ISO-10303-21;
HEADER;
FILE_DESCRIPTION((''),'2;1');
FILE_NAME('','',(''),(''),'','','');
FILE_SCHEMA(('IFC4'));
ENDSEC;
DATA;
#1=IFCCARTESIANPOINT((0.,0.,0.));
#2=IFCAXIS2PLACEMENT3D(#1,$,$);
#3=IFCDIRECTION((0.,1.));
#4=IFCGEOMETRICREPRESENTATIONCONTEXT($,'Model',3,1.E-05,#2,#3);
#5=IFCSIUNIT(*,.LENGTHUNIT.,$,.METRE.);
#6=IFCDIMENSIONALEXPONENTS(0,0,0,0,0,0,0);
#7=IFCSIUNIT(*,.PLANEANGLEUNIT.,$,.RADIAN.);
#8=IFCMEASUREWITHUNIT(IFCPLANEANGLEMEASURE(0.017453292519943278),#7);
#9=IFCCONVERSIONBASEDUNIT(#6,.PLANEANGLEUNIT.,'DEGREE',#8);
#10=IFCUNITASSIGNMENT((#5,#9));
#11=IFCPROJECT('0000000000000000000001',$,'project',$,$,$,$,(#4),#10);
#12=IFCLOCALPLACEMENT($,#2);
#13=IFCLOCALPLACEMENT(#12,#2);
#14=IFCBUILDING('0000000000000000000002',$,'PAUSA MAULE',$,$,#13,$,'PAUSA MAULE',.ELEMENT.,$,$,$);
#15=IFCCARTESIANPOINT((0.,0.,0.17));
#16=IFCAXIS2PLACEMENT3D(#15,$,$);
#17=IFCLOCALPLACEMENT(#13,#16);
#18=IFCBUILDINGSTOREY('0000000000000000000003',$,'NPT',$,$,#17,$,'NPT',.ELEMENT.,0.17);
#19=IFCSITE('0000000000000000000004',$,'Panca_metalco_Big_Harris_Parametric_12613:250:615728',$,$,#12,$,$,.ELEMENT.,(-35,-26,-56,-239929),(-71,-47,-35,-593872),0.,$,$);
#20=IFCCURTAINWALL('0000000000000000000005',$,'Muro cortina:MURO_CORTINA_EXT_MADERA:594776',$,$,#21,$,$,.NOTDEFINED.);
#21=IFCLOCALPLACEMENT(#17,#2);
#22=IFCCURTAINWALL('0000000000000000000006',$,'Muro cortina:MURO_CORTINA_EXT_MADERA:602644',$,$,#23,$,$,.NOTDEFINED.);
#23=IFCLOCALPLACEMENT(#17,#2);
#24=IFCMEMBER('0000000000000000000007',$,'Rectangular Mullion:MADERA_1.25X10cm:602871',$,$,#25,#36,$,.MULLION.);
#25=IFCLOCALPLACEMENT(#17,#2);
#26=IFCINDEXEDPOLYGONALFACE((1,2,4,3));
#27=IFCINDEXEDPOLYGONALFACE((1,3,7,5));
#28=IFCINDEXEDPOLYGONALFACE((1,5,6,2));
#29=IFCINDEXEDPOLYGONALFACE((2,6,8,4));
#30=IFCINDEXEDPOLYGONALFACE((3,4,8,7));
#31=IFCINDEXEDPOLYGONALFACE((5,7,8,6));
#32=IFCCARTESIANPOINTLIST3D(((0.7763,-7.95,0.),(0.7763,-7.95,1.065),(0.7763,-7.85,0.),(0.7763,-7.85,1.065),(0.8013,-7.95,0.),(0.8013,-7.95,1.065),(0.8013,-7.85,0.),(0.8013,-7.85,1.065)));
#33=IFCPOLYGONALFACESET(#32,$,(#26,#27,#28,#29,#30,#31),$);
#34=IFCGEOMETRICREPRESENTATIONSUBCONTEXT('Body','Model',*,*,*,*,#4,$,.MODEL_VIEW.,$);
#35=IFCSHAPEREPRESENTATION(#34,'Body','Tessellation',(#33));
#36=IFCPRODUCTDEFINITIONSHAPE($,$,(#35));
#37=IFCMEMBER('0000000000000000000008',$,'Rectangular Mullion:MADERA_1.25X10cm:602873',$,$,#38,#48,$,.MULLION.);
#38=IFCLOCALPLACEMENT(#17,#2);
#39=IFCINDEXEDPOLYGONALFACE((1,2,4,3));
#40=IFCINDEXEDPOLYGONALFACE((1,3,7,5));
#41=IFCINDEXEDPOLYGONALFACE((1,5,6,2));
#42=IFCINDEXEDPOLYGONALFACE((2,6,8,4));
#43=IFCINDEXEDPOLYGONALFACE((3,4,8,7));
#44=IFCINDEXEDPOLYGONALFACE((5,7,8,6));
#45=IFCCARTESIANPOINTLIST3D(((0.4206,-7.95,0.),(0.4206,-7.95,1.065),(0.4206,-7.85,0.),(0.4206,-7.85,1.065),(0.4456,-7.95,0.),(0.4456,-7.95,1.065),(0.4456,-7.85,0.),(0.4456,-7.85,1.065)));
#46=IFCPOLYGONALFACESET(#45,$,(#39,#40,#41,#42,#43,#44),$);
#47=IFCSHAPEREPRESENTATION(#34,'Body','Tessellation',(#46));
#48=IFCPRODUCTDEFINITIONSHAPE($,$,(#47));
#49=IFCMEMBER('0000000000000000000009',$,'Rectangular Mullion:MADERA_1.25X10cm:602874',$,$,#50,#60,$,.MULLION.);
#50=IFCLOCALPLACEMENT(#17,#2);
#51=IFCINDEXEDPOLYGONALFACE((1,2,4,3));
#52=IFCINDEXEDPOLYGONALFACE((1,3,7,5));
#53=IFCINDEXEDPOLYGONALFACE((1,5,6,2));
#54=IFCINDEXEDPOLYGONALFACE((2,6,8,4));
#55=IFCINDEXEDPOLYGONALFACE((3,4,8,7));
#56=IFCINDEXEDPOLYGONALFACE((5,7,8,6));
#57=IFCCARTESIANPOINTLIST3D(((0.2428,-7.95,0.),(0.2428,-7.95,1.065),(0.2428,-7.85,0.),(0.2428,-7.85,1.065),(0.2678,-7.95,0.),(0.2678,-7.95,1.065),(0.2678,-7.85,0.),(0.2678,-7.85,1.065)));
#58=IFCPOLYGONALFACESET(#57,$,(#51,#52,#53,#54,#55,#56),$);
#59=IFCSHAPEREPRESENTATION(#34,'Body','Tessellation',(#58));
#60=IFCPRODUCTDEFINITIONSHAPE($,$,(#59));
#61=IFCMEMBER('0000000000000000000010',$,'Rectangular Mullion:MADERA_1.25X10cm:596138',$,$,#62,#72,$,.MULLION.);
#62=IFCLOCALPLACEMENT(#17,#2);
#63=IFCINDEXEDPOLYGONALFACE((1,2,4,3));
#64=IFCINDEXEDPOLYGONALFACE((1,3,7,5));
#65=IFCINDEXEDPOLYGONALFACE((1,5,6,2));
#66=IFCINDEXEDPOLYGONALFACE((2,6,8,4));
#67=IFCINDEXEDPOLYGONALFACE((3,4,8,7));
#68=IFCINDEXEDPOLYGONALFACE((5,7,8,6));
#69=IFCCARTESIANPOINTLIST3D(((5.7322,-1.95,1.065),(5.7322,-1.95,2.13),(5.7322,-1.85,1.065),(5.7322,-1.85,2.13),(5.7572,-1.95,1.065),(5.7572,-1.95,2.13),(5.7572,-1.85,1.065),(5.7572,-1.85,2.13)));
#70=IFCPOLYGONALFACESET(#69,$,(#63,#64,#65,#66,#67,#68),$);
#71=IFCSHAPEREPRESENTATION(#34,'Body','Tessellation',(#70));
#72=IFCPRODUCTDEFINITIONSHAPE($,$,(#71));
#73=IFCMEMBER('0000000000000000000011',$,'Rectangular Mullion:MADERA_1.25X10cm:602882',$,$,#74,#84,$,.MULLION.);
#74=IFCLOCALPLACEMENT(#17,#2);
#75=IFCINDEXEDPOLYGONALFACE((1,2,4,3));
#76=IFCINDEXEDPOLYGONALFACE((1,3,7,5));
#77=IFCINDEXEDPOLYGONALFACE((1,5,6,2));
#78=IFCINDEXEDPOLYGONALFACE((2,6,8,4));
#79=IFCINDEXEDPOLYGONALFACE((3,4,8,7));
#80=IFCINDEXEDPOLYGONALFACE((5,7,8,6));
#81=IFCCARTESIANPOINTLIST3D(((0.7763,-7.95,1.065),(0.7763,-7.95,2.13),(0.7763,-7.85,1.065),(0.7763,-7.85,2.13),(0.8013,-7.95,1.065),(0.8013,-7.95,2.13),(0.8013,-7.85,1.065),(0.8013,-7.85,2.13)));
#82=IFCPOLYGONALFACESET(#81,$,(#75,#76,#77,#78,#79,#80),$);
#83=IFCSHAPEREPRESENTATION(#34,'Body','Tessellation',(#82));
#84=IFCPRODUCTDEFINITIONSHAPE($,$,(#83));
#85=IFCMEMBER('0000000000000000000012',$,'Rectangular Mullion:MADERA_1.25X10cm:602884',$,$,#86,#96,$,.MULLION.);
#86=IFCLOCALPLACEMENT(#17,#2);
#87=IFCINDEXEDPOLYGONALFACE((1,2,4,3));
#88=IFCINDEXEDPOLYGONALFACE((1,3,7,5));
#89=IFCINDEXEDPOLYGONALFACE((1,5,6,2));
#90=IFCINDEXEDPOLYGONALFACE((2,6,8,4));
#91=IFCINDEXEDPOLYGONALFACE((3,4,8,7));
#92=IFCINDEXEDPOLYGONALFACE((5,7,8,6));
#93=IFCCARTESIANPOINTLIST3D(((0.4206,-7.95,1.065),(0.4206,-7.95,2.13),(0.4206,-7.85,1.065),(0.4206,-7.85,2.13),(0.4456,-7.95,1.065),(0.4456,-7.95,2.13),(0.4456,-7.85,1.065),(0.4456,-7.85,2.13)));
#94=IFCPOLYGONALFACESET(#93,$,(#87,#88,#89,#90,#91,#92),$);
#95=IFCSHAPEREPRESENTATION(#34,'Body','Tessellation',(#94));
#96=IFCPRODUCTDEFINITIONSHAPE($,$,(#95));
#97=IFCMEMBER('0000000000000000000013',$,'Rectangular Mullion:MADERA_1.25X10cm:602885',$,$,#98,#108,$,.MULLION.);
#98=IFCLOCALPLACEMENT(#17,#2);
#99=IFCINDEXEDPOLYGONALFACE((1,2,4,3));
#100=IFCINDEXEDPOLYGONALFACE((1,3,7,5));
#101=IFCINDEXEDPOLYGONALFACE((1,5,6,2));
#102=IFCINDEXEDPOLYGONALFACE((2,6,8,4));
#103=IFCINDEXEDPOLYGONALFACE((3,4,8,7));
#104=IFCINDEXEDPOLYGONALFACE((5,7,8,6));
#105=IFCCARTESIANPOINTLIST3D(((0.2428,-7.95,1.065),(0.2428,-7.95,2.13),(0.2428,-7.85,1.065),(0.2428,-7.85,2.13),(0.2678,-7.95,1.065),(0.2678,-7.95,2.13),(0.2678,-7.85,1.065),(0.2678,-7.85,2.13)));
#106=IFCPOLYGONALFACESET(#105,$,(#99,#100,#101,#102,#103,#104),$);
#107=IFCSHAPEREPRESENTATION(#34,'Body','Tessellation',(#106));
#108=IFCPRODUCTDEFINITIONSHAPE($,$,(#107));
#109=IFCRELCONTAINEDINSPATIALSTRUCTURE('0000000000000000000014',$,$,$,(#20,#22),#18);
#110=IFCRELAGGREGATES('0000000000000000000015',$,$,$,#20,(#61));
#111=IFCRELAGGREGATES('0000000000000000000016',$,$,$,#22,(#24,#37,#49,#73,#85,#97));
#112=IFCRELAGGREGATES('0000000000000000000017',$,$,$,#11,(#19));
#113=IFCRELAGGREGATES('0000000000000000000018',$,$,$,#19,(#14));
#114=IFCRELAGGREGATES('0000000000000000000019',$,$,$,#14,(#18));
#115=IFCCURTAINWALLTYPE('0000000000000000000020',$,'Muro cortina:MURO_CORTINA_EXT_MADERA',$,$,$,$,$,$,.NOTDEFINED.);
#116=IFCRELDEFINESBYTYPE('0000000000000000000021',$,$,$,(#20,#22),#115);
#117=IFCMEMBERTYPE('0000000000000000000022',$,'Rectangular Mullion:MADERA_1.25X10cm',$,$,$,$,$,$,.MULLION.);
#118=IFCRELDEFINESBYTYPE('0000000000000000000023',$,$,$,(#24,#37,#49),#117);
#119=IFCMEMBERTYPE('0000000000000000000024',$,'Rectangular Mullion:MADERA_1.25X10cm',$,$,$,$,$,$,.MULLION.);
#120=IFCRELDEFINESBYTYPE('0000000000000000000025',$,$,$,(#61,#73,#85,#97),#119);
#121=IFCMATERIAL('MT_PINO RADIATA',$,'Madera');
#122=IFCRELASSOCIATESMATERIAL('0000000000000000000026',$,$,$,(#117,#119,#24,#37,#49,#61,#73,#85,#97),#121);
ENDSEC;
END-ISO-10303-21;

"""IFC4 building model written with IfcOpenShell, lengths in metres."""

from ifc_helpers import new_model, entity, si_unit, converted_unit, direction, frame, frame_2d, origin, place, context, subcontext, project, spatial, rectangle, extrude, source, transform, mapped, material, material_profile, profile_set, profile_usage, type_object, type_shapes, element, aggregate, save


model = new_model("IFC4")

# Units and contexts
model_context = context("Model", 3, precision=1e-05, world=origin(), true_north=direction((0.0, 1.0)))
body_context = subcontext(model_context, "Body", "Model", "MODEL_VIEW")
ifc_project = project(units=[si_unit("LENGTHUNIT", "METRE"), converted_unit("PLANEANGLEUNIT", "DEGREE", entity("IfcPlaneAngleMeasure", 0.017453292519943278), si_unit("PLANEANGLEUNIT", "RADIAN"), dimensions=[0, 0, 0, 0, 0, 0, 0])], contexts=[model_context])

# Site, building, storey
site_placement = place(None, origin())
site = spatial("IfcSite", under=ifc_project, at=site_placement, Name="Panca_metalco_Big_Harris_Parametric_12613:250:615728", CompositionType="ELEMENT", RefLatitude=(-35, -26, -56, -239929), RefLongitude=(-71, -47, -35, -593872), RefElevation=0.0)
building_placement = place(site_placement, origin())
building = spatial("IfcBuilding", under=site, at=building_placement, Name="PAUSA MAULE", LongName="PAUSA MAULE", CompositionType="ELEMENT")
storey_placement = place(building_placement, frame((0.0, 0.0, 0.17)))
storey = spatial("IfcBuildingStorey", under=building, at=storey_placement, Name="NPT", LongName="NPT", CompositionType="ELEMENT", Elevation=0.17)

# Curtain wall
curtain_wall_type = type_object("IfcCurtainWallType", Name="Muro cortina:MURO_CORTINA_EXT_MADERA", PredefinedType="NOTDEFINED")
curtain_wall_1_placement = place(storey_placement, frame((0.0, 0.0, -0.17)))
curtain_wall_1 = element("IfcCurtainWall", 1, at=curtain_wall_1_placement, inside=storey, type_object=curtain_wall_type, Name="Muro cortina:MURO_CORTINA_EXT_MADERA:594776", PredefinedType="NOTDEFINED")
ifc_material_1 = material(Name="MT_PINO RADIATA", Category="Madera")
ifc_material_profile = material_profile(ifc_material_1, rectangle(XDim=0.025, YDim=0.1, at=frame_2d((0.0, 0.0), x_axis=(1.0, 0.0))), Name="MADERA_1.25X10cm")
ifc_profile_set = profile_set([ifc_material_profile], Name="MADERA_1.25X10cm")
ifc_profile_usage = profile_usage(ifc_profile_set)

# Curtain wall
curtain_wall_2_placement = place(storey_placement, frame((0.0, 0.0, -0.17)))
curtain_wall_2 = element("IfcCurtainWall", 2, at=curtain_wall_2_placement, inside=storey, type_object=curtain_wall_type, Name="Muro cortina:MURO_CORTINA_EXT_MADERA:602644", PredefinedType="NOTDEFINED")

# Members
member_type_1 = type_object("IfcMemberType", Name="Rectangular Mullion:MADERA_1.25X10cm", PredefinedType="MULLION", material=ifc_profile_set)
shared_shape_1 = source(origin(), body_context, "Body", "SweptSolid", [
    extrude(rectangle(XDim=0.025, YDim=0.1, at=frame_2d((0.0, 0.0), x_axis=(1.0, 0.0))), frame((0.0, 0.0, -1.065), z_axis=(0.0, 0.0, 1.0), x_axis=(-1.0, 0.0, 0.0)), (0.0, 0.0, 1.0), 1.065),
])
type_shapes(member_type_1, [shared_shape_1])
member_1_placement = place(curtain_wall_2_placement, frame((0.7888, -7.9, 0.17), z_axis=(0.0, 0.0, -1.0), x_axis=(-1.0, 0.0, 0.0)))
member_1 = element("IfcMember", 3, at=member_1_placement, type_object=member_type_1, material=ifc_profile_usage, Name="Rectangular Mullion:MADERA_1.25X10cm:602871", PredefinedType="MULLION", context=body_context, shape_type="MappedRepresentation", body=[
    mapped(shared_shape_1, transform((0.0, 0.0, 0.0), scale=1.0)),
])
member_2_placement = place(curtain_wall_2_placement, frame((0.4331, -7.9, 0.17), z_axis=(0.0, 0.0, -1.0), x_axis=(-1.0, 0.0, 0.0)))
member_2 = element("IfcMember", 4, at=member_2_placement, type_object=member_type_1, material=ifc_profile_usage, Name="Rectangular Mullion:MADERA_1.25X10cm:602873", PredefinedType="MULLION", context=body_context, shape_type="MappedRepresentation", body=[
    mapped(shared_shape_1, transform((0.0, 0.0, 0.0), scale=1.0)),
])
member_3_placement = place(curtain_wall_2_placement, frame((0.2553, -7.9, 0.17), z_axis=(0.0, 0.0, -1.0), x_axis=(-1.0, 0.0, 0.0)))
member_3 = element("IfcMember", 5, at=member_3_placement, type_object=member_type_1, material=ifc_profile_usage, Name="Rectangular Mullion:MADERA_1.25X10cm:602874", PredefinedType="MULLION", context=body_context, shape_type="MappedRepresentation", body=[
    mapped(shared_shape_1, transform((0.0, 0.0, 0.0), scale=1.0)),
])
member_type_2 = type_object("IfcMemberType", Name="Rectangular Mullion:MADERA_1.25X10cm", PredefinedType="MULLION", material=ifc_profile_set)
shared_shape_2 = source(origin(), body_context, "Body", "SweptSolid", [
    extrude(rectangle(XDim=0.025, YDim=0.1, at=frame_2d((0.0, 0.0), x_axis=(1.0, 0.0))), frame((0.0, 0.0, -1.065), z_axis=(0.0, 0.0, 1.0), x_axis=(-1.0, 0.0, 0.0)), (0.0, 0.0, 1.0), 1.065),
])
type_shapes(member_type_2, [shared_shape_2])
member_4_placement = place(curtain_wall_1_placement, frame((5.7447, -1.9, 1.235), z_axis=(0.0, 0.0, -1.0), x_axis=(1.0, 0.0, 0.0)))
member_4 = element("IfcMember", 6, at=member_4_placement, type_object=member_type_2, material=ifc_profile_usage, Name="Rectangular Mullion:MADERA_1.25X10cm:596138", PredefinedType="MULLION", context=body_context, shape_type="MappedRepresentation", body=[
    mapped(shared_shape_2, transform((0.0, 0.0, 0.0), scale=1.0)),
])
aggregate(curtain_wall_1, [member_4])
member_5_placement = place(curtain_wall_2_placement, frame((0.7888, -7.9, 1.235), z_axis=(0.0, 0.0, -1.0), x_axis=(-1.0, 0.0, 0.0)))
member_5 = element("IfcMember", 7, at=member_5_placement, type_object=member_type_2, material=ifc_profile_usage, Name="Rectangular Mullion:MADERA_1.25X10cm:602882", PredefinedType="MULLION", context=body_context, shape_type="MappedRepresentation", body=[
    mapped(shared_shape_2, transform((0.0, 0.0, 0.0), scale=1.0)),
])
member_6_placement = place(curtain_wall_2_placement, frame((0.4331, -7.9, 1.235), z_axis=(0.0, 0.0, -1.0), x_axis=(-1.0, 0.0, 0.0)))
member_6 = element("IfcMember", 8, at=member_6_placement, type_object=member_type_2, material=ifc_profile_usage, Name="Rectangular Mullion:MADERA_1.25X10cm:602884", PredefinedType="MULLION", context=body_context, shape_type="MappedRepresentation", body=[
    mapped(shared_shape_2, transform((0.0, 0.0, 0.0), scale=1.0)),
])
member_7_placement = place(curtain_wall_2_placement, frame((0.2553, -7.9, 1.235), z_axis=(0.0, 0.0, -1.0), x_axis=(-1.0, 0.0, 0.0)))
member_7 = element("IfcMember", 9, at=member_7_placement, type_object=member_type_2, material=ifc_profile_usage, Name="Rectangular Mullion:MADERA_1.25X10cm:602885", PredefinedType="MULLION", context=body_context, shape_type="MappedRepresentation", body=[
    mapped(shared_shape_2, transform((0.0, 0.0, 0.0), scale=1.0)),
])
aggregate(curtain_wall_2, [member_1, member_2, member_3, member_5, member_6, member_7])

save(model, "model.ifc")
